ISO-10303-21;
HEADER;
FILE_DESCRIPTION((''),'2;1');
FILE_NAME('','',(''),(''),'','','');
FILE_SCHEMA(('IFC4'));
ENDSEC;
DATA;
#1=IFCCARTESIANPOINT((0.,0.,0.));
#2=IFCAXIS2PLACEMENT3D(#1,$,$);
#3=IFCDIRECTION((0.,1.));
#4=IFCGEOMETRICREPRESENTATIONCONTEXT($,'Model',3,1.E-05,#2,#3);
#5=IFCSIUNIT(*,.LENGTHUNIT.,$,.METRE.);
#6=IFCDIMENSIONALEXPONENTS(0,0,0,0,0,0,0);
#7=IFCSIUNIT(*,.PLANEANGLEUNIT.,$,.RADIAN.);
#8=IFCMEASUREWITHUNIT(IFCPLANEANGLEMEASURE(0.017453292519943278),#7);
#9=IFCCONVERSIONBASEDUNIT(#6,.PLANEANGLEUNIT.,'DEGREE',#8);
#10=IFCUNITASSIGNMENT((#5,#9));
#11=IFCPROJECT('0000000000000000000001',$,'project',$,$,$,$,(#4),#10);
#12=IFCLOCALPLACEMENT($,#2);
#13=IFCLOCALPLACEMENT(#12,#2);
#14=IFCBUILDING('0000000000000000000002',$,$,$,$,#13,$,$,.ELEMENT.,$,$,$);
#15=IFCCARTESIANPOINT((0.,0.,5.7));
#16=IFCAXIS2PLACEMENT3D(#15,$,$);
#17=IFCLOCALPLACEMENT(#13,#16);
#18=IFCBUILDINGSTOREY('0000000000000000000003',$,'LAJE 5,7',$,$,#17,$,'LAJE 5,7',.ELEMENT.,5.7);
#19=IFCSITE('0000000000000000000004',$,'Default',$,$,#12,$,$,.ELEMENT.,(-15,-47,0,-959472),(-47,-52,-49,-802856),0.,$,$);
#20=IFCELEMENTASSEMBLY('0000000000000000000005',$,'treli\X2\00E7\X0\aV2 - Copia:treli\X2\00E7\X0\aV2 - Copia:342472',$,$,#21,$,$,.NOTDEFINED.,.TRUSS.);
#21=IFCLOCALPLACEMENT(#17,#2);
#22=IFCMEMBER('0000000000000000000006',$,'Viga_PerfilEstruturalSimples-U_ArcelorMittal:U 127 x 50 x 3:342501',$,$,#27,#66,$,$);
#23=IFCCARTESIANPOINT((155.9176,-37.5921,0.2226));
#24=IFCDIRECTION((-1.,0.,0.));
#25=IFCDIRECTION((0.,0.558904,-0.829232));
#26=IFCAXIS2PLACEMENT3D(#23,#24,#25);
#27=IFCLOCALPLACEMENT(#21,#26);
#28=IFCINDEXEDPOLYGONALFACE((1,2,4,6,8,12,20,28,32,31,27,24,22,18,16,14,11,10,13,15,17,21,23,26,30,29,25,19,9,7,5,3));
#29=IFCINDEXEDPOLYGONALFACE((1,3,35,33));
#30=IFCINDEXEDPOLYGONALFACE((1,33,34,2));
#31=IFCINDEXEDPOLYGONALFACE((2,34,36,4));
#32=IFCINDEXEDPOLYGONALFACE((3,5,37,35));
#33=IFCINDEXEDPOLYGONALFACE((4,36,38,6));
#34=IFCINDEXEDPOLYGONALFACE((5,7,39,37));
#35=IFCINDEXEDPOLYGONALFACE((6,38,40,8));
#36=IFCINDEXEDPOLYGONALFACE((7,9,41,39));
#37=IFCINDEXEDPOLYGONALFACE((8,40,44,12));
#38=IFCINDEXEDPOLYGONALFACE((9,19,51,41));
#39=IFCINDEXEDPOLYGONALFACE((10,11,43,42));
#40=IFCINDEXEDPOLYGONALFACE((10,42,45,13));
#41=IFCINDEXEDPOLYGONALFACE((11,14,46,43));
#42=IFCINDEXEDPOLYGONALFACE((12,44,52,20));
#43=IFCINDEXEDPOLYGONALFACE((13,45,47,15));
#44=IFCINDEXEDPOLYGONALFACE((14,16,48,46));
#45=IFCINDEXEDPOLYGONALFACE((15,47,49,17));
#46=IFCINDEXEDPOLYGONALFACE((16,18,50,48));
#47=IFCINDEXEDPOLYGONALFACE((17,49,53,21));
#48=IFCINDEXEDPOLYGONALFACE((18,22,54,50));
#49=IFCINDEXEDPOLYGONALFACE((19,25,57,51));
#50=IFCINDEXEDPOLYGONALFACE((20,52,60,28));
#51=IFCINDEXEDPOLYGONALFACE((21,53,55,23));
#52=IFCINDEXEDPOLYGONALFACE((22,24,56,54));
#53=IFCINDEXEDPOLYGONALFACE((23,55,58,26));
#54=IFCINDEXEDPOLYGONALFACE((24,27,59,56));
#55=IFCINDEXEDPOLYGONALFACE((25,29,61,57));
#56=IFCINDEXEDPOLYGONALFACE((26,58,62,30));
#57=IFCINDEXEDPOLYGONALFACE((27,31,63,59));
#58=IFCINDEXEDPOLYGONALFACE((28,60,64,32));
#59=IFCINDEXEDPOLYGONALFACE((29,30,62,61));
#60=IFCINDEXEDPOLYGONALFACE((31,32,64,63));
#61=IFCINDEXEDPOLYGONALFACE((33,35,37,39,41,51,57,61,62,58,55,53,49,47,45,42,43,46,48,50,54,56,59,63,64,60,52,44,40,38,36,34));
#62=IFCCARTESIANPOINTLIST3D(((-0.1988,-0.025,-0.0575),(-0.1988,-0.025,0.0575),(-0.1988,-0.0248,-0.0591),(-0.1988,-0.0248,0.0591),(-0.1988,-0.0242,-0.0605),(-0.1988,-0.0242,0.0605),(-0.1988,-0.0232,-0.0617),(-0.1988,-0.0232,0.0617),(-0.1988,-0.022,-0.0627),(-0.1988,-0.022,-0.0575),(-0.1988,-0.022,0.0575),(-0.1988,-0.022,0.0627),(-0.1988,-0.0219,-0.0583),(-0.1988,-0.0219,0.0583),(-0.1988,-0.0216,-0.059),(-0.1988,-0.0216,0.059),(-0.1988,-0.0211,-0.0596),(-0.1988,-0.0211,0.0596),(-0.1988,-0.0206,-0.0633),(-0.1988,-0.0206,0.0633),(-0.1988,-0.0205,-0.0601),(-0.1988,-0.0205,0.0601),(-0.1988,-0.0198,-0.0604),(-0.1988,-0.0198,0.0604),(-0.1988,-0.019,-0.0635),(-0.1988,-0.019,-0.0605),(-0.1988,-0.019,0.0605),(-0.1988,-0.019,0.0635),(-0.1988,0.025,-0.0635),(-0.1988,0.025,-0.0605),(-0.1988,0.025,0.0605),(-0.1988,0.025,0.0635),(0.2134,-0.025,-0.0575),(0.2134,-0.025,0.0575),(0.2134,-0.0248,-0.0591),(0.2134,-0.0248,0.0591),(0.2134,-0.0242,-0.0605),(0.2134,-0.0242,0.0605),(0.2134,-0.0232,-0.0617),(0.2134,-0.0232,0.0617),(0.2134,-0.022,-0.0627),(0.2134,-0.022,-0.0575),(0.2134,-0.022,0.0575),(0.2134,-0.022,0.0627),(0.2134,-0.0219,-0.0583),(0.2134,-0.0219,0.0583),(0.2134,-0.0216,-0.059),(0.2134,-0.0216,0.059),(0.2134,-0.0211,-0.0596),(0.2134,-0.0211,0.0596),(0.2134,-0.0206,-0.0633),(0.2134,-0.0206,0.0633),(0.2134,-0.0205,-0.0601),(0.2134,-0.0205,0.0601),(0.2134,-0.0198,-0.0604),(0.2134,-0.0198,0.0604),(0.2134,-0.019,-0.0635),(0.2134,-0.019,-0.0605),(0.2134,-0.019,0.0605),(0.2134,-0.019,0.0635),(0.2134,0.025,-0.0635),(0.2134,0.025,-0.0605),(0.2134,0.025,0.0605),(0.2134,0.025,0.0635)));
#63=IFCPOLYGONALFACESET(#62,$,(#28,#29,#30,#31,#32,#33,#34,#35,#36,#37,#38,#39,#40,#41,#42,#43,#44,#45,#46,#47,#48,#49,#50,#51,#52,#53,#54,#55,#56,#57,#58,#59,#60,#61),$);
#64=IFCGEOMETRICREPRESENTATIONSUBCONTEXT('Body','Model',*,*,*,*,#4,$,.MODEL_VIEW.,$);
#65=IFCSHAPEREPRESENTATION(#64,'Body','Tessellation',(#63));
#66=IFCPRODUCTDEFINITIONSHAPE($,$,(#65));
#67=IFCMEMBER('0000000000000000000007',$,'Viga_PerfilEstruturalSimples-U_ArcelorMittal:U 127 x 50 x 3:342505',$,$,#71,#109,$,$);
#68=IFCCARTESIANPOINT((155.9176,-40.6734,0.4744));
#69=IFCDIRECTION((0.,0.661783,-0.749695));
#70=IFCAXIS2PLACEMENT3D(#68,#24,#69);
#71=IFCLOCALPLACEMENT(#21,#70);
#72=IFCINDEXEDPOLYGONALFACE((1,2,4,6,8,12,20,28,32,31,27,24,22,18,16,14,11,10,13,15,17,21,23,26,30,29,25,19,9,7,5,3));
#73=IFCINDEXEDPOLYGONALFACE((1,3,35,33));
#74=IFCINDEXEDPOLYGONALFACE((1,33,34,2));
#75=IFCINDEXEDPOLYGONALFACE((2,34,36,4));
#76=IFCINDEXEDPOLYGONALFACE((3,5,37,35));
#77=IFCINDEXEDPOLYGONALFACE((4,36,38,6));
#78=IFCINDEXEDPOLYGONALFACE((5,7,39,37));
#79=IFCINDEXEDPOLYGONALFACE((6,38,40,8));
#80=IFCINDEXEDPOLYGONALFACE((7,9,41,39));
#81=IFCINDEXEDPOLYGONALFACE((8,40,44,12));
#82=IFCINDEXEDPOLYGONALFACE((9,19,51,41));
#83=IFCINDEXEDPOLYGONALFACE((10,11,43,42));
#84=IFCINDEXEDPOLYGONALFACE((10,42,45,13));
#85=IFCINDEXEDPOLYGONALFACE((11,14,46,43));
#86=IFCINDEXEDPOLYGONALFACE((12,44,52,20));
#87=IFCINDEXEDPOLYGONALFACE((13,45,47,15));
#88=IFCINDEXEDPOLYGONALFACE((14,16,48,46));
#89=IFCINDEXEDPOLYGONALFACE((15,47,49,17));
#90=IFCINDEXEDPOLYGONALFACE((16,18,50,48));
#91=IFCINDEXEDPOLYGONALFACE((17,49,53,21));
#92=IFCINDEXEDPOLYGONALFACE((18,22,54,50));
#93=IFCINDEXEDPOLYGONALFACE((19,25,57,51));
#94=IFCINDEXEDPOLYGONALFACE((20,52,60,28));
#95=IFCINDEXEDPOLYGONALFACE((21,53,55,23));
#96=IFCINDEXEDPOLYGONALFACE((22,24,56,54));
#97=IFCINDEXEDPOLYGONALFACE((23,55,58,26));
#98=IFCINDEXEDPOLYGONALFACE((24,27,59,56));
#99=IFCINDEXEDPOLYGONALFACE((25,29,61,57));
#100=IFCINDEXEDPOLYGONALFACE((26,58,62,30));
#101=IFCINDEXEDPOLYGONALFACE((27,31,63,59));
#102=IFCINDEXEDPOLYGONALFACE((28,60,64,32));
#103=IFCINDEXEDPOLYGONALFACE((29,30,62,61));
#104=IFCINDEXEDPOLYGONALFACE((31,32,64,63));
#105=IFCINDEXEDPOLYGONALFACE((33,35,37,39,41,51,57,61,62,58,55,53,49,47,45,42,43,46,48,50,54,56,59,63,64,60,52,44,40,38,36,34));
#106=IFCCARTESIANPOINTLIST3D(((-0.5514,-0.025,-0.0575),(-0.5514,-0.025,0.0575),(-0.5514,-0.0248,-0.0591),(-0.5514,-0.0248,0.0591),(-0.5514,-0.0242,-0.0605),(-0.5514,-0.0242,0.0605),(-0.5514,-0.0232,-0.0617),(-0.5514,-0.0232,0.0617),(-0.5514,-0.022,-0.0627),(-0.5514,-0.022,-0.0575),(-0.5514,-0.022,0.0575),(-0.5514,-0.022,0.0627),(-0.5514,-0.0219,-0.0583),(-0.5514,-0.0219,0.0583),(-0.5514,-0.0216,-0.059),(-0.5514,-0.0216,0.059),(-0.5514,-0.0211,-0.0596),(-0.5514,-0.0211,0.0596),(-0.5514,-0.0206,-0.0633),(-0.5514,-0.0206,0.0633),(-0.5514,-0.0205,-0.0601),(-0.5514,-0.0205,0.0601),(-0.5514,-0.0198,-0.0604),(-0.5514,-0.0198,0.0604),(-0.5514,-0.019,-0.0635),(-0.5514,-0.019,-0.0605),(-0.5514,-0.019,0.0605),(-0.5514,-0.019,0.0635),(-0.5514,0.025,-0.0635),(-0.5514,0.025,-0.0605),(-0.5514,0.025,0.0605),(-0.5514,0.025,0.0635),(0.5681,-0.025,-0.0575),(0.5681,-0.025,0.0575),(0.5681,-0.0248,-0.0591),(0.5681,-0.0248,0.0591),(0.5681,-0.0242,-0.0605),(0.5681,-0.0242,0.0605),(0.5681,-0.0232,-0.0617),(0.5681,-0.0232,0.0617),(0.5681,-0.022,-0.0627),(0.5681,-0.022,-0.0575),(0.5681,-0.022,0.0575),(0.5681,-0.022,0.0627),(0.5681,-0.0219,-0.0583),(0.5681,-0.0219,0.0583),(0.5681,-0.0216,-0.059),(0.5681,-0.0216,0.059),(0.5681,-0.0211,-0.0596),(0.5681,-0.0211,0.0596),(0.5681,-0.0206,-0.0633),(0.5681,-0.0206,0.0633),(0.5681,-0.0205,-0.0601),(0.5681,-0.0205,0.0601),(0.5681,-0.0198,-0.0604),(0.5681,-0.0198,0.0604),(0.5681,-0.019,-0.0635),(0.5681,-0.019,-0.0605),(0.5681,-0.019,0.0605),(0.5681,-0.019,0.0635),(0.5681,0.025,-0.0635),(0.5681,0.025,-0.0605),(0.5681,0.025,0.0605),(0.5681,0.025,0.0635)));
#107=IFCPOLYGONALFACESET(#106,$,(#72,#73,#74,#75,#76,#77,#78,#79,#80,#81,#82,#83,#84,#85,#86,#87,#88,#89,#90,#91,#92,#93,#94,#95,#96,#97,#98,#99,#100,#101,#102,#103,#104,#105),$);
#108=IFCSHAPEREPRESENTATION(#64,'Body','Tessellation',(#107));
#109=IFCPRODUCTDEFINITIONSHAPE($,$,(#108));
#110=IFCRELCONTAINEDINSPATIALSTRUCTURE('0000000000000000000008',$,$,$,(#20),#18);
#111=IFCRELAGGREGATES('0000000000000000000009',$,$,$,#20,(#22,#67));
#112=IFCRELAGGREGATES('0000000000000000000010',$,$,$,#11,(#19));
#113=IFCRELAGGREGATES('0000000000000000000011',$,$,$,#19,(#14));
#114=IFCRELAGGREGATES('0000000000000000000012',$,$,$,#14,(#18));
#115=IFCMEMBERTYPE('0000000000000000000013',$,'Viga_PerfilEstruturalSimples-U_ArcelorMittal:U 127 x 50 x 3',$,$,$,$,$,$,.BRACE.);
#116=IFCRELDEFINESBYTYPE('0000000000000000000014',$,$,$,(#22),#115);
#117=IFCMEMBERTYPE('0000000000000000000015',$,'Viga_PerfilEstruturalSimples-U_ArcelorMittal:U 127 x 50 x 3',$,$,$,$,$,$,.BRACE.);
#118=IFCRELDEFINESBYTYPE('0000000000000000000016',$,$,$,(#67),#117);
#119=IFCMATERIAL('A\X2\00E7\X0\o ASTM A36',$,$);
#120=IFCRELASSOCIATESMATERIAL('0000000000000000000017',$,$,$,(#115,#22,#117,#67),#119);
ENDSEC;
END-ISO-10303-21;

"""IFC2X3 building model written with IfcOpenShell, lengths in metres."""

from ifc_helpers import new_model, entity, si_unit, converted_unit, direction, frame, frame_2d, origin, place, context, subcontext, project, spatial, polyline, circle_curve, parameter, trimmed, segment, composite_curve, outline, extrude, source, transform, mapped, material, type_object, type_shapes, element, aggregate, save


model = new_model("IFC2X3")

# Units and contexts
model_context = context("Model", 3, precision=1e-05, world=origin(), true_north=direction((0.0, 1.0)))
body_context = subcontext(model_context, "Body", "Model", "MODEL_VIEW")
ifc_project = project(units=[si_unit("LENGTHUNIT", "METRE"), converted_unit("PLANEANGLEUNIT", "DEGREE", entity("IfcPlaneAngleMeasure", 0.017453292519943278), si_unit("PLANEANGLEUNIT", "RADIAN"), dimensions=[0, 0, 0, 0, 0, 0, 0])], contexts=[model_context])

# Site, building, storey
site_placement = place(None, origin())
site = spatial("IfcSite", under=ifc_project, at=site_placement, Name="Default", CompositionType="ELEMENT", RefLatitude=(-15, -47, 0, -959472), RefLongitude=(-47, -52, -49, -802856), RefElevation=0.0)
building_placement = place(site_placement, origin())
building = spatial("IfcBuilding", under=site, at=building_placement, CompositionType="ELEMENT")
storey_placement = place(building_placement, frame((0.0, 0.0, 5.7)))
storey = spatial("IfcBuildingStorey", under=building, at=storey_placement, Name="LAJE 5,7", LongName="LAJE 5,7", CompositionType="ELEMENT", Elevation=5.7)

# Element assembly, members
ifc_material = material(Name="Aço ASTM A36")
assembly_1_placement = place(storey_placement, origin())
assembly_1 = element("IfcElementAssembly", 1, at=assembly_1_placement, inside=storey, Name="treliçaV2 - Copia:treliçaV2 - Copia:342472", AssemblyPlace="NOTDEFINED", PredefinedType="TRUSS")
member_type_1 = type_object("IfcMemberType", Name="Viga_PerfilEstruturalSimples-U_ArcelorMittal:U 127 x 50 x 3", PredefinedType="BRACE", material=ifc_material)
shared_shape_1 = source(origin(), body_context, "Body", "SweptSolid", [
    extrude(outline(composite_curve([segment(polyline([(-0.0575, -0.0192), (0.0575, -0.0192)]), True, "CONTINUOUS"), segment(trimmed(circle_curve(frame_2d((0.0575, -0.0132), x_axis=(0.0, 1.0)), 0.006), [parameter(180.0)], [parameter(270.0)], True, "PARAMETER"), True, "CONTINUOUS"), segment(polyline([(0.0635, -0.0132), (0.0635, 0.0308)]), True, "CONTINUOUS"), segment(polyline([(0.0635, 0.0308), (0.0605, 0.0308)]), True, "CONTINUOUS"), segment(polyline([(0.0605, 0.0308), (0.0605, -0.0132)]), True, "CONTINUOUS"), segment(trimmed(circle_curve(frame_2d((0.0575, -0.0132), x_axis=(0.0, 1.0)), 0.003), [parameter(180.0)], [parameter(270.0)], True, "PARAMETER"), False, "CONTINUOUS"), segment(polyline([(0.0575, -0.0162), (-0.0575, -0.0162)]), True, "CONTINUOUS"), segment(trimmed(circle_curve(frame_2d((-0.0575, -0.0132), x_axis=(0.0, 1.0)), 0.003), [parameter(90.0)], [parameter(180.0)], True, "PARAMETER"), False, "CONTINUOUS"), segment(polyline([(-0.0605, -0.0132), (-0.0605, 0.0308)]), True, "CONTINUOUS"), segment(polyline([(-0.0605, 0.0308), (-0.0635, 0.0308)]), True, "CONTINUOUS"), segment(polyline([(-0.0635, 0.0308), (-0.0635, -0.0132)]), True, "CONTINUOUS"), segment(trimmed(circle_curve(frame_2d((-0.0575, -0.0132), x_axis=(0.0, 1.0)), 0.006), [parameter(90.0)], [parameter(180.0)], True, "PARAMETER"), True, "CONTINUOUS")], self_intersect=False)), frame((-0.1988, -0.0058, 0.0), z_axis=(1.0, 0.0, 0.0), x_axis=(0.0, 0.0, -1.0)), (0.0, 0.0, 1.0), 0.4122),
])
type_shapes(member_type_1, [shared_shape_1])
member_1_placement = place(assembly_1_placement, frame((155.9176, -37.5921, 0.2226), z_axis=(-1.0, 0.0, 0.0), x_axis=(0.0, 0.558904, -0.829232)))
member_1 = element("IfcMember", 2, at=member_1_placement, type_object=member_type_1, material=ifc_material, Name="Viga_PerfilEstruturalSimples-U_ArcelorMittal:U 127 x 50 x 3:342501", context=body_context, shape_type="MappedRepresentation", body=[
    mapped(shared_shape_1, transform((0.0, 0.0, 0.0), scale=1.0)),
])
member_type_2 = type_object("IfcMemberType", Name="Viga_PerfilEstruturalSimples-U_ArcelorMittal:U 127 x 50 x 3", PredefinedType="BRACE", material=ifc_material)
shared_shape_2 = source(origin(), body_context, "Body", "SweptSolid", [
    extrude(outline(composite_curve([segment(polyline([(-0.0575, -0.0192), (0.0575, -0.0192)]), True, "CONTINUOUS"), segment(trimmed(circle_curve(frame_2d((0.0575, -0.0132), x_axis=(0.0, 1.0)), 0.006), [parameter(180.0)], [parameter(270.0)], True, "PARAMETER"), True, "CONTINUOUS"), segment(polyline([(0.0635, -0.0132), (0.0635, 0.0308)]), True, "CONTINUOUS"), segment(polyline([(0.0635, 0.0308), (0.0605, 0.0308)]), True, "CONTINUOUS"), segment(polyline([(0.0605, 0.0308), (0.0605, -0.0132)]), True, "CONTINUOUS"), segment(trimmed(circle_curve(frame_2d((0.0575, -0.0132), x_axis=(0.0, 1.0)), 0.003), [parameter(180.0)], [parameter(270.0)], True, "PARAMETER"), False, "CONTINUOUS"), segment(polyline([(0.0575, -0.0162), (-0.0575, -0.0162)]), True, "CONTINUOUS"), segment(trimmed(circle_curve(frame_2d((-0.0575, -0.0132), x_axis=(0.0, 1.0)), 0.003), [parameter(90.0)], [parameter(180.0)], True, "PARAMETER"), False, "CONTINUOUS"), segment(polyline([(-0.0605, -0.0132), (-0.0605, 0.0308)]), True, "CONTINUOUS"), segment(polyline([(-0.0605, 0.0308), (-0.0635, 0.0308)]), True, "CONTINUOUS"), segment(polyline([(-0.0635, 0.0308), (-0.0635, -0.0132)]), True, "CONTINUOUS"), segment(trimmed(circle_curve(frame_2d((-0.0575, -0.0132), x_axis=(0.0, 1.0)), 0.006), [parameter(90.0)], [parameter(180.0)], True, "PARAMETER"), True, "CONTINUOUS")], self_intersect=False)), frame((-0.5514, -0.0058, 0.0), z_axis=(1.0, 0.0, 0.0), x_axis=(0.0, 0.0, -1.0)), (0.0, 0.0, 1.0), 1.1195),
])
type_shapes(member_type_2, [shared_shape_2])
member_2_placement = place(assembly_1_placement, frame((155.9176, -40.6734, 0.4744), z_axis=(-1.0, 0.0, 0.0), x_axis=(0.0, 0.661783, -0.749695)))
member_2 = element("IfcMember", 3, at=member_2_placement, type_object=member_type_2, material=ifc_material, Name="Viga_PerfilEstruturalSimples-U_ArcelorMittal:U 127 x 50 x 3:342505", context=body_context, shape_type="MappedRepresentation", body=[
    mapped(shared_shape_2, transform((0.0, 0.0, 0.0), scale=1.0)),
])
aggregate(assembly_1, [member_1, member_2])

save(model, "model.ifc")
